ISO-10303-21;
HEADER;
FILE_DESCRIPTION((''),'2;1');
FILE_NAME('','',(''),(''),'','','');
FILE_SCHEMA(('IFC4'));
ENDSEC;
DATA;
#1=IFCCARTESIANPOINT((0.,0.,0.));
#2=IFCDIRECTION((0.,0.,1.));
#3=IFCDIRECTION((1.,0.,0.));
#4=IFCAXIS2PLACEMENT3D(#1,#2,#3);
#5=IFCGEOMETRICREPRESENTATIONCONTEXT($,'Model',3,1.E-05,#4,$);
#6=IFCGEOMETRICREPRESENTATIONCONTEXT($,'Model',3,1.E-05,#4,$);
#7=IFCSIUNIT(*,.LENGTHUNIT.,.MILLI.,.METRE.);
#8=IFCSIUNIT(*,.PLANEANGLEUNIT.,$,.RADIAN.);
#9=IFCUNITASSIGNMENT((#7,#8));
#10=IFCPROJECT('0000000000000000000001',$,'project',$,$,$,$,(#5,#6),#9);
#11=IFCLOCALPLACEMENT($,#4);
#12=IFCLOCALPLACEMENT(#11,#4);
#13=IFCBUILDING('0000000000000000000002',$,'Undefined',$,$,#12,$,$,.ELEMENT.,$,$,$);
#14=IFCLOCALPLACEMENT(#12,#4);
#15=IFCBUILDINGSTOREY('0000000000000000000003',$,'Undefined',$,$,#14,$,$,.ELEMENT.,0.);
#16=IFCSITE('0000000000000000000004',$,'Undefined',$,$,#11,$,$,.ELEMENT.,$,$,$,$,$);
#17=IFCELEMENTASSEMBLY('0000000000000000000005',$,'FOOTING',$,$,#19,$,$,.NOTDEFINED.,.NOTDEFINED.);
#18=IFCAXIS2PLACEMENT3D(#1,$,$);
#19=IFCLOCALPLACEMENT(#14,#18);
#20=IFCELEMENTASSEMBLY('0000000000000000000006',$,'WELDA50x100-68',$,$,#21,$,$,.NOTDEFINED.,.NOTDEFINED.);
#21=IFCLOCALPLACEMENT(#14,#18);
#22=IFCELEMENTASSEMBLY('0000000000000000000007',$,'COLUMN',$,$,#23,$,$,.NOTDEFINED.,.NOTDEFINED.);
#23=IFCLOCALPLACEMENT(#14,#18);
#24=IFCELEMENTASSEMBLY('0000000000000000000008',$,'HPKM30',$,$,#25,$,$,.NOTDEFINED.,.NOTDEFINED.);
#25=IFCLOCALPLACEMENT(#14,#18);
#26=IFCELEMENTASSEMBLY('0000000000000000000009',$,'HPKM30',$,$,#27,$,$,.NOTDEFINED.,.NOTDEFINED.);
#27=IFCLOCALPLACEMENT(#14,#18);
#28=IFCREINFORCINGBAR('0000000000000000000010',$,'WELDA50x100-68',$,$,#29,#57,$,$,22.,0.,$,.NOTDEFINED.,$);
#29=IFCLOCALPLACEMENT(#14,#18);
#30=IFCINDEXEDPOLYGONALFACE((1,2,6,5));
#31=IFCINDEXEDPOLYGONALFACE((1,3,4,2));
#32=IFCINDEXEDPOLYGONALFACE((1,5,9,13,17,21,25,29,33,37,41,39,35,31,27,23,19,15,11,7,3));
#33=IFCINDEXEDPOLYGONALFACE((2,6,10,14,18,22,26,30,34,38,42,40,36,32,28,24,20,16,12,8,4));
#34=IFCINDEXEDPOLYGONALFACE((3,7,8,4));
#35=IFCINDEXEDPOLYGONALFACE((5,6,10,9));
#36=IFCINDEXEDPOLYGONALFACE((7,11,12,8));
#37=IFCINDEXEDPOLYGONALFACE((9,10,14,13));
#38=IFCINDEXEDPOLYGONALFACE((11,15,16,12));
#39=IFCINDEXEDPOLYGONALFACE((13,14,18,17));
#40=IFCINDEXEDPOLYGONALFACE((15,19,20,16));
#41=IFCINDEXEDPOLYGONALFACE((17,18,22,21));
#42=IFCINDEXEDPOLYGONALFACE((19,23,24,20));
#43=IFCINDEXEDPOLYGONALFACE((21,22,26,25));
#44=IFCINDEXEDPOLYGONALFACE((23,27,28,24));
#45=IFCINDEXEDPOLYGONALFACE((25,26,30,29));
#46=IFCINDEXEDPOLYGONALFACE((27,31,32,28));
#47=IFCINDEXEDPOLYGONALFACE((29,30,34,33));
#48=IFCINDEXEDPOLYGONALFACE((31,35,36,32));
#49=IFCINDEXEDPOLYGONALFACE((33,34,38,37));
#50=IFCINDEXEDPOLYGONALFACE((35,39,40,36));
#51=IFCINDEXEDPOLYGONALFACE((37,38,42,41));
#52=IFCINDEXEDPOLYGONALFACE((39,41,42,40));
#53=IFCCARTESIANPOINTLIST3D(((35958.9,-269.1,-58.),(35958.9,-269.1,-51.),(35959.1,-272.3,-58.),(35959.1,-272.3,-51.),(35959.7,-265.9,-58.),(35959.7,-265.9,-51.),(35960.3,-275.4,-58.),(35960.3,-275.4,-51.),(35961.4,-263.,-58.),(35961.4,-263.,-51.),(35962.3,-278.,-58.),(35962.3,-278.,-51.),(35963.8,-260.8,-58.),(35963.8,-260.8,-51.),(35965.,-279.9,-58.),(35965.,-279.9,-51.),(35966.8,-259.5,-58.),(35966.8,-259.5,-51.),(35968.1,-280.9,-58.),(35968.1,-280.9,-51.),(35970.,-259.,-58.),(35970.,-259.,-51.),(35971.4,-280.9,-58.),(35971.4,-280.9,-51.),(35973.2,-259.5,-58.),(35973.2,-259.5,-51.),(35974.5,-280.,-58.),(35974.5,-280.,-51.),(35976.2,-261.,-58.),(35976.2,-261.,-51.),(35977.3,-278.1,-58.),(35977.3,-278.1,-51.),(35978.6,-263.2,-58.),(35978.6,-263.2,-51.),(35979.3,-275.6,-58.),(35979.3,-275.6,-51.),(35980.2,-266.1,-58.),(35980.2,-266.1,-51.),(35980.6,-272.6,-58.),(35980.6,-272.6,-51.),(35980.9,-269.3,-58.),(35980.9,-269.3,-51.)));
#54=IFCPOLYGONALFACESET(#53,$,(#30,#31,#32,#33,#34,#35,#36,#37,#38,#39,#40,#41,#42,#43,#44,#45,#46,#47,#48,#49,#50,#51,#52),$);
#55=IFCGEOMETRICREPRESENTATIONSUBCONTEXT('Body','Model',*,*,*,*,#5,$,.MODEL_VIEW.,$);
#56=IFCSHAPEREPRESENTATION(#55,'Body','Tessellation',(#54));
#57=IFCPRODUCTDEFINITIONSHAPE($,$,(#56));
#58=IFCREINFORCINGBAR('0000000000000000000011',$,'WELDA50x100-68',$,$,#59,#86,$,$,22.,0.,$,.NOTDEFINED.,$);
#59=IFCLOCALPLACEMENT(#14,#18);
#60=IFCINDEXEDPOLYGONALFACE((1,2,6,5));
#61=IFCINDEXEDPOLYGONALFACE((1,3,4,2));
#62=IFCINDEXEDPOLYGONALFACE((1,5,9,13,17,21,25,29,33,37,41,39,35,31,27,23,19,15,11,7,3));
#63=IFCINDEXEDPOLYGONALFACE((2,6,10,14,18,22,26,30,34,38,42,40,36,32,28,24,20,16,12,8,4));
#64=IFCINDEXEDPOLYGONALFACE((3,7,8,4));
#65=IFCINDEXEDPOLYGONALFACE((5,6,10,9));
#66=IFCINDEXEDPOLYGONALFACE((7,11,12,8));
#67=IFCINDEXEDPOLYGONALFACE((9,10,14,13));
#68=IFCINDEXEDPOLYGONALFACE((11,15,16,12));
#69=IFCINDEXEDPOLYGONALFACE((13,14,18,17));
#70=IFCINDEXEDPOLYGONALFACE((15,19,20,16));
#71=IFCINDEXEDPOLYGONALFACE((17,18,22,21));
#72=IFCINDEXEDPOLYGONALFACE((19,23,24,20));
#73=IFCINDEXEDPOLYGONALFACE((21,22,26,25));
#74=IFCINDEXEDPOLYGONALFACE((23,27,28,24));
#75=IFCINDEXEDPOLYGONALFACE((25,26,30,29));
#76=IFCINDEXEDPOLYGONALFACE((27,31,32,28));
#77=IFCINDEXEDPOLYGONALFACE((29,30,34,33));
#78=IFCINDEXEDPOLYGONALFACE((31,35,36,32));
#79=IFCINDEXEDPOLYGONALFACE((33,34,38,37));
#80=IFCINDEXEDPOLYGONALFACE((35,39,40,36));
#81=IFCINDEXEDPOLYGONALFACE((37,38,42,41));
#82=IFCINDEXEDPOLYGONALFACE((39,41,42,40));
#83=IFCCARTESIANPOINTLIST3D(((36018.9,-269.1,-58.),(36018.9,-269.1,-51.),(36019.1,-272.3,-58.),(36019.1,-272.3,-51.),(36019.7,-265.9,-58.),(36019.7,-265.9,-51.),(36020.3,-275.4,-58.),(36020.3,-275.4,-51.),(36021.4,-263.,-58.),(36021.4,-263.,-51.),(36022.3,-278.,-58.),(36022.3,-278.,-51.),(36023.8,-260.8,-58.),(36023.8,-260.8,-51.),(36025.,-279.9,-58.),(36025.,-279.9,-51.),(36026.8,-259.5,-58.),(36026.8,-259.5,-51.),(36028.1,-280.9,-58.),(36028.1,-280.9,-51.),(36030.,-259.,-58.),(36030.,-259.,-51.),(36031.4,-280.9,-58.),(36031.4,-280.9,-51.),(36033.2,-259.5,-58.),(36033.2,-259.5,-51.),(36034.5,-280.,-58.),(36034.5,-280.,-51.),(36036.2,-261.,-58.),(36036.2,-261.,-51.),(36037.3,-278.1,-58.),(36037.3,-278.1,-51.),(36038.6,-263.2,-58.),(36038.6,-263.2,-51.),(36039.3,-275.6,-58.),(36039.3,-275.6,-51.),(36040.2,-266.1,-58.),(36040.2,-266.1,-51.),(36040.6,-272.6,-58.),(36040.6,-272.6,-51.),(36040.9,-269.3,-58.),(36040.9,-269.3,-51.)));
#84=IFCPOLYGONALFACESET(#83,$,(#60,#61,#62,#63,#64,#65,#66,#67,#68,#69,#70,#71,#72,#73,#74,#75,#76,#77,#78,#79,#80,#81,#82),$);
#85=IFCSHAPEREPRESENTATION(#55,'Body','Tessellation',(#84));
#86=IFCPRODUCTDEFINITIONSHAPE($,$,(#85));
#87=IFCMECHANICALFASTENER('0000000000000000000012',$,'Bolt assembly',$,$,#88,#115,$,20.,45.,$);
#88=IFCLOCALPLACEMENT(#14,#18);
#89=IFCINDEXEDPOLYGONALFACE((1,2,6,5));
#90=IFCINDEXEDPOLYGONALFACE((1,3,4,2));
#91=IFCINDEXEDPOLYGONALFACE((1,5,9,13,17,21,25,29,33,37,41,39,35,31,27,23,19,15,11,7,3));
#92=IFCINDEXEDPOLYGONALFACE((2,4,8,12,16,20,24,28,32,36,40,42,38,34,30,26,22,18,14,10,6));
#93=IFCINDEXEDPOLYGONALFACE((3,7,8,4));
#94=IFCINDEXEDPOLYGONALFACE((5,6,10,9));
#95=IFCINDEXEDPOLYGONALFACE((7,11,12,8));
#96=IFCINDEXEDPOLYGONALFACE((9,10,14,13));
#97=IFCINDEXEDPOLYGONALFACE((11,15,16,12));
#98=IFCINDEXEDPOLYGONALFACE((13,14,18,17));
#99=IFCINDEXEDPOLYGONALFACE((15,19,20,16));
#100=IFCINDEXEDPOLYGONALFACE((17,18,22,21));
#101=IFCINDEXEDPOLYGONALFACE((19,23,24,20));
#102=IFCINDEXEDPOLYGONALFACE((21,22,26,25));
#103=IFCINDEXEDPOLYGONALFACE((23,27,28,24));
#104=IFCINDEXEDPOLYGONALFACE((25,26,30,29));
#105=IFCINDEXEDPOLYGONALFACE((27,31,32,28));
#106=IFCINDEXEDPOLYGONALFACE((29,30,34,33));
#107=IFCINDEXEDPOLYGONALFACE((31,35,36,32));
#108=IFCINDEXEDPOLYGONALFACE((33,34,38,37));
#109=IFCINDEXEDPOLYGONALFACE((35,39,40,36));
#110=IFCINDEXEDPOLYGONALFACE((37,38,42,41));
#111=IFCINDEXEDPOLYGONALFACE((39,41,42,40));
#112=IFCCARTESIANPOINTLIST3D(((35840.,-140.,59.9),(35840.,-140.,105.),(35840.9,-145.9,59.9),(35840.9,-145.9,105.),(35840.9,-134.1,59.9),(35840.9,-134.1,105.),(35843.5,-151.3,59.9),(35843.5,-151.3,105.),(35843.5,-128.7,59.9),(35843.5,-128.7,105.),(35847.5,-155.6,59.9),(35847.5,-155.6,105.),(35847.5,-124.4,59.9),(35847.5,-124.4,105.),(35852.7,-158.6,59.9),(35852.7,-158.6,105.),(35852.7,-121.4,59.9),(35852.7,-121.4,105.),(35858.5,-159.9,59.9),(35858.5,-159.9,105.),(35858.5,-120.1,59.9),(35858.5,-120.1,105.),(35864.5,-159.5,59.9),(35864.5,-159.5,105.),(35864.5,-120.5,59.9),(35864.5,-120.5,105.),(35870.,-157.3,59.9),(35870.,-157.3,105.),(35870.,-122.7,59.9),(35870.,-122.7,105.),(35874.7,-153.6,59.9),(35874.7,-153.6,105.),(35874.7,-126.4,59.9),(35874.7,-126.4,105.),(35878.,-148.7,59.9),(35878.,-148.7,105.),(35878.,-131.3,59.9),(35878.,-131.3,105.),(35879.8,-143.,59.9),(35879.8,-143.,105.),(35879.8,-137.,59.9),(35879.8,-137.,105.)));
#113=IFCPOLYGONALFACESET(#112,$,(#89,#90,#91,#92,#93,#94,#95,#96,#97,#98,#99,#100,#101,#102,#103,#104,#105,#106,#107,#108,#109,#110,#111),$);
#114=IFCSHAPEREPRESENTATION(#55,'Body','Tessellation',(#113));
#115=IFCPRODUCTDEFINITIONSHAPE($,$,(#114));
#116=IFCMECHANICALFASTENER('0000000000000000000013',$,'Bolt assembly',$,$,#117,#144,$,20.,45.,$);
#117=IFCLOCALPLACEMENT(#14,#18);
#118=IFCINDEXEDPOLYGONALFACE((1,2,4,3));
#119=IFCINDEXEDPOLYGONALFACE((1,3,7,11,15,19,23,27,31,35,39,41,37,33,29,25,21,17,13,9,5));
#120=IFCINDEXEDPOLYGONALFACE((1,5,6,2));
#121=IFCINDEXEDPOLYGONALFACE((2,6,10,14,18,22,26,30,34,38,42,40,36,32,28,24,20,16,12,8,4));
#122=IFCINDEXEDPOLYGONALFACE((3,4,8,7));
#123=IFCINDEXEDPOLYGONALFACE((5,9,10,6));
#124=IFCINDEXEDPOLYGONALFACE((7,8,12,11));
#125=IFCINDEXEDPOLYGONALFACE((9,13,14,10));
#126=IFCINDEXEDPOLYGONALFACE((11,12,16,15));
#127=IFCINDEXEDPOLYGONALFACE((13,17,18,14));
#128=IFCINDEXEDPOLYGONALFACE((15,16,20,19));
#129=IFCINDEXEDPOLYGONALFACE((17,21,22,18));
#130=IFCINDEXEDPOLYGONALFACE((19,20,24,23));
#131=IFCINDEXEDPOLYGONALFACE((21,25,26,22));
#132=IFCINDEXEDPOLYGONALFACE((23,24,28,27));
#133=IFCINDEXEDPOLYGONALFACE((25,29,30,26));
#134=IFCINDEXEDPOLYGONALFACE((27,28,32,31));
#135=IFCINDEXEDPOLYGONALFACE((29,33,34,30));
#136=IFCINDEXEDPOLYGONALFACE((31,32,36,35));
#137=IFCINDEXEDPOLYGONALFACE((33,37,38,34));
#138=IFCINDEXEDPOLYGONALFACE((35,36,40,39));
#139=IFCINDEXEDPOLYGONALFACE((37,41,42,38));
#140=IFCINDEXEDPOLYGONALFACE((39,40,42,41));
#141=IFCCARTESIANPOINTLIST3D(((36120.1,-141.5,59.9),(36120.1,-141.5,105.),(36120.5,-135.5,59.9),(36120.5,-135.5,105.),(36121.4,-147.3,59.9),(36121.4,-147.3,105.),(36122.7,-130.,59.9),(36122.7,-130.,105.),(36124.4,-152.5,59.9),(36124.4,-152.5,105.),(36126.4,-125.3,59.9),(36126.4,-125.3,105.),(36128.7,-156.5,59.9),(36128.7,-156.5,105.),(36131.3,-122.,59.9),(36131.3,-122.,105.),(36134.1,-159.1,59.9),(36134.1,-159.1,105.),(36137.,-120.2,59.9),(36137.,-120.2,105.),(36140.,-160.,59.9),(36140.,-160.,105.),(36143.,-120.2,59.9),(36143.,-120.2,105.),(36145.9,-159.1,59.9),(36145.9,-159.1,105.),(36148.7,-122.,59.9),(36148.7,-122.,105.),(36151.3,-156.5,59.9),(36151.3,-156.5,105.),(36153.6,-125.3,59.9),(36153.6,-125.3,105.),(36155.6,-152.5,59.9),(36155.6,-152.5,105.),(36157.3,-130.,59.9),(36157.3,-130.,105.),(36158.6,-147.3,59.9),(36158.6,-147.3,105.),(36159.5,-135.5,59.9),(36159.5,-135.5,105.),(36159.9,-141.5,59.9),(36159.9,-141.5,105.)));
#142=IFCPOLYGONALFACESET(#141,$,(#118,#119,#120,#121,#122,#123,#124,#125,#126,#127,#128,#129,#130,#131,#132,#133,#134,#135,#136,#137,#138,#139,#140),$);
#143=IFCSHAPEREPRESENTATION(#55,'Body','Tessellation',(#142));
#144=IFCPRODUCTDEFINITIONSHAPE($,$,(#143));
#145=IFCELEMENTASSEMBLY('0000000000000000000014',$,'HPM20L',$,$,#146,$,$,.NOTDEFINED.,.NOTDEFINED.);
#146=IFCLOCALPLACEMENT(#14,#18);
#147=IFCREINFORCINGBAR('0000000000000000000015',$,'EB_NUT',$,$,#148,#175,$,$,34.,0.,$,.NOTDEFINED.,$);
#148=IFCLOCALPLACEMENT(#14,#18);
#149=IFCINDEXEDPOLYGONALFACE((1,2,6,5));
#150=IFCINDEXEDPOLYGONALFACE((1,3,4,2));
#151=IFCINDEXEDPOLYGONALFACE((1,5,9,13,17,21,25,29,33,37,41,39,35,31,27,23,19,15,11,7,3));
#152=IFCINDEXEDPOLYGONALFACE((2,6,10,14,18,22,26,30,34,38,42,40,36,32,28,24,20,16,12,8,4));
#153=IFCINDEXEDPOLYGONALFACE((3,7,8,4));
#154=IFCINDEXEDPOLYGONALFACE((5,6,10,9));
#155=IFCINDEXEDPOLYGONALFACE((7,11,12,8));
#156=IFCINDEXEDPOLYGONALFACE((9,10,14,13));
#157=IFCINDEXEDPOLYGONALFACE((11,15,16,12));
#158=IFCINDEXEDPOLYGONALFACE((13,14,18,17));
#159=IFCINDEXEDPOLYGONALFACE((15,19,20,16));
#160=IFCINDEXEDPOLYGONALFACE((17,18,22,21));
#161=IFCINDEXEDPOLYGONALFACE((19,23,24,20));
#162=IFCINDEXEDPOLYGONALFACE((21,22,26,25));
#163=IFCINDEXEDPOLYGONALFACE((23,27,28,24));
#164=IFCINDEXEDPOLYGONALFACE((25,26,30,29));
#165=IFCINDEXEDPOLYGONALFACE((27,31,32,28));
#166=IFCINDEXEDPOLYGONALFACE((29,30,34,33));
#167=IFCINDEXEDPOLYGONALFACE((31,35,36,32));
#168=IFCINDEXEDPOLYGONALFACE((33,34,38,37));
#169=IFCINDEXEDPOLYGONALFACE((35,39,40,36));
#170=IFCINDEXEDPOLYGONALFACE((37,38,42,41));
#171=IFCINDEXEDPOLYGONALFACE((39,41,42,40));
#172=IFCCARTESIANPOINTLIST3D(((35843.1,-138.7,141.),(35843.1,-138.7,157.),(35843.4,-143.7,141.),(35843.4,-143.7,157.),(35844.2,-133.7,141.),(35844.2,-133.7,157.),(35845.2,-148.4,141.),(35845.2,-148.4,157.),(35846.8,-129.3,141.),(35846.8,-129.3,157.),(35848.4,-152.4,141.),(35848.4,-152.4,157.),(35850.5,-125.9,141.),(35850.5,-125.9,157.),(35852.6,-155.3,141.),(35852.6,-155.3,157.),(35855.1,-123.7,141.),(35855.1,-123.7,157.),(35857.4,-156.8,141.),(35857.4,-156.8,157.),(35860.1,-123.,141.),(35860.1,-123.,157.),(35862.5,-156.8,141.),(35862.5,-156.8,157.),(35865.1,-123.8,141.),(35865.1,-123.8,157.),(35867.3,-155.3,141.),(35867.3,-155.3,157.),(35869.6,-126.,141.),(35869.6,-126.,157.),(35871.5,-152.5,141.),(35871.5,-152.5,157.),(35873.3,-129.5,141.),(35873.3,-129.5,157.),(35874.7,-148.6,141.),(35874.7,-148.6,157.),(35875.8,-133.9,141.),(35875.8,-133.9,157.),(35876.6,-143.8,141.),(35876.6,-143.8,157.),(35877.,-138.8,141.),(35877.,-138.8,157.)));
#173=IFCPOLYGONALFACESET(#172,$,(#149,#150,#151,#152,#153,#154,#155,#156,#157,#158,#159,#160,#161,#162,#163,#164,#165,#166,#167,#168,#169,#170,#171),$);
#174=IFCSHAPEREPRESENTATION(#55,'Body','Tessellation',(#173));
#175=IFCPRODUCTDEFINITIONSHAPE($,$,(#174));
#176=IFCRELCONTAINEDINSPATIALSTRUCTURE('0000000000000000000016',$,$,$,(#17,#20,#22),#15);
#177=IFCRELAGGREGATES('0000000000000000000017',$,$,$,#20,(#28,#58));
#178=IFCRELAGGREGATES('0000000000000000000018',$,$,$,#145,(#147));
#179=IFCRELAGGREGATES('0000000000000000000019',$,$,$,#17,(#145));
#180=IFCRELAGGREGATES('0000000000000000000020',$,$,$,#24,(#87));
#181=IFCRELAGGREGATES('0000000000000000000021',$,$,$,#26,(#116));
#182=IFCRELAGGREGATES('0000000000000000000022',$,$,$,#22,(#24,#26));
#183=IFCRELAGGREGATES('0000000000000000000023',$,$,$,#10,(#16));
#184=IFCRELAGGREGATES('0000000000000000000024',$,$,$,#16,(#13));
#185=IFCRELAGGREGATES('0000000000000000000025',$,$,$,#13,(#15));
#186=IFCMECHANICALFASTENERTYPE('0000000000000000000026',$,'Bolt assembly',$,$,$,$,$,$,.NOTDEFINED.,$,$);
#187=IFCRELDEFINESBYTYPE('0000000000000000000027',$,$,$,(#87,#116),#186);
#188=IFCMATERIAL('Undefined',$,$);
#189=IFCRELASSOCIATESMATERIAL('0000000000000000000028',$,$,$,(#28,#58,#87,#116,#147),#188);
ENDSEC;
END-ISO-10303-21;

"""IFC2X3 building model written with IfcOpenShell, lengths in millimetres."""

from ifc_helpers import new_model, entity, si_unit, frame, origin_with_axes, origin_2d_with_axis, place, context, subcontext, project, spatial, circle, extrude, source, transform, mapped, material, type_object, element, aggregate, save


model = new_model("IFC2X3")

# Units and contexts
model_context_1 = context("Model", 3, precision=1e-05, world=origin_with_axes())
model_context_2 = context("Model", 3, precision=1e-05, world=origin_with_axes())
body_context = subcontext(model_context_1, "Body", "Model", "MODEL_VIEW")
ifc_project = project(units=[si_unit("LENGTHUNIT", "METRE", prefix="MILLI"), si_unit("PLANEANGLEUNIT", "RADIAN")], contexts=[model_context_1, model_context_2])

# Site, building, storey
site_placement = place(None, origin_with_axes())
site = spatial("IfcSite", under=ifc_project, at=site_placement, Name="Undefined", CompositionType="ELEMENT")
building_placement = place(site_placement, origin_with_axes())
building = spatial("IfcBuilding", under=site, at=building_placement, Name="Undefined", CompositionType="ELEMENT")
storey_placement = place(building_placement, origin_with_axes())
storey = spatial("IfcBuildingStorey", under=building, at=storey_placement, Name="Undefined", CompositionType="ELEMENT", Elevation=0.0)

# Element assembly
assembly_1_placement = place(storey_placement, origin_with_axes())
assembly_1 = element("IfcElementAssembly", 1, at=assembly_1_placement, inside=storey, Name="FOOTING", AssemblyPlace="NOTDEFINED", PredefinedType="NOTDEFINED")

# Element assembly
assembly_2_placement = place(storey_placement, origin_with_axes())
assembly_2 = element("IfcElementAssembly", 2, at=assembly_2_placement, inside=storey, Name="WELDA50x100-68", AssemblyPlace="NOTDEFINED", PredefinedType="NOTDEFINED")

# Element assemblies
assembly_3_placement = place(storey_placement, origin_with_axes())
assembly_3 = element("IfcElementAssembly", 3, at=assembly_3_placement, inside=storey, Name="COLUMN", AssemblyPlace="NOTDEFINED", PredefinedType="NOTDEFINED")
assembly_4_placement = place(assembly_3_placement, origin_with_axes())
assembly_4 = element("IfcElementAssembly", 4, at=assembly_4_placement, Name="HPKM30", AssemblyPlace="NOTDEFINED", PredefinedType="NOTDEFINED")
assembly_5_placement = place(assembly_3_placement, origin_with_axes())
assembly_5 = element("IfcElementAssembly", 5, at=assembly_5_placement, Name="HPKM30", AssemblyPlace="NOTDEFINED", PredefinedType="NOTDEFINED")

# Reinforcing bars
ifc_material_1 = material(Name="Undefined")
shared_shape_1 = source(origin_with_axes(), body_context, "Body", "AdvancedSweptSolid", [
    entity("IfcSweptDiskSolid", entity("IfcTrimmedCurve", entity("IfcLine", entity("IfcCartesianPoint", [0.0, 0.0, 0.0]), entity("IfcVector", entity("IfcDirection", [1.0, 0.0, 0.0]), 1.0)), [entity("IfcParameterValue", 0.0)], [entity("IfcParameterValue", 7.0)], True, "PARAMETER"), 11.0, None, 0.0, 7.0),
])
reinforcing_bar_1_placement = place(assembly_2_placement, frame((35969.9, -270.0, -51.0), z_axis=(0.011111, 0.999938, 0.0), x_axis=(0.0, 0.0, -1.0)))
reinforcing_bar_1 = element("IfcReinforcingBar", 6, at=reinforcing_bar_1_placement, material=ifc_material_1, Name="WELDA50x100-68", BarRole="NOTDEFINED", CrossSectionArea=0.0, NominalDiameter=22.0, context=body_context, shape_type="MappedRepresentation", body=[
    mapped(shared_shape_1, transform((0.0, 0.0, 0.0))),
])
shared_shape_2 = source(origin_with_axes(), body_context, "Body", "AdvancedSweptSolid", [
    entity("IfcSweptDiskSolid", entity("IfcTrimmedCurve", entity("IfcLine", entity("IfcCartesianPoint", [0.0, 0.0, 0.0]), entity("IfcVector", entity("IfcDirection", [1.0, 0.0, 0.0]), 1.0)), [entity("IfcParameterValue", 0.0)], [entity("IfcParameterValue", 7.0)], True, "PARAMETER"), 11.0, None, 0.0, 7.0),
])
reinforcing_bar_2_placement = place(assembly_2_placement, frame((36029.9, -270.0, -51.0), z_axis=(0.011111, 0.999938, 0.0), x_axis=(0.0, 0.0, -1.0)))
reinforcing_bar_2 = element("IfcReinforcingBar", 7, at=reinforcing_bar_2_placement, material=ifc_material_1, Name="WELDA50x100-68", BarRole="NOTDEFINED", CrossSectionArea=0.0, NominalDiameter=22.0, context=body_context, shape_type="MappedRepresentation", body=[
    mapped(shared_shape_2, transform((0.0, 0.0, 0.0))),
])
aggregate(assembly_2, [reinforcing_bar_1, reinforcing_bar_2])

# Mechanical fasteners
mechanical_fastener_type = type_object("IfcMechanicalFastenerType", Name="Bolt assembly")
shared_shape_3 = source(origin_with_axes(), body_context, "Body", "SweptSolid", [
    extrude(circle(Radius=20.0, at=origin_2d_with_axis()), frame((0.0, -45.0, 0.0), z_axis=(0.0, 1.0, 0.0), x_axis=(1.0, 0.0, 0.0)), (0.0, 0.0, 1.0), 45.1),
])
mechanical_fastener_1_placement = place(assembly_4_placement, frame((35860.0, -140.0, 60.0), z_axis=(0.0, -1.0, 0.0), x_axis=(-1.0, 0.0, 0.0)))
mechanical_fastener_1 = element("IfcMechanicalFastener", 8, at=mechanical_fastener_1_placement, type_object=mechanical_fastener_type, material=ifc_material_1, Name="Bolt assembly", NominalDiameter=20.0, NominalLength=45.0, context=body_context, shape_type="MappedRepresentation", body=[
    mapped(shared_shape_3, transform((0.0, 0.0, 0.0))),
])
mechanical_fastener_2_placement = place(assembly_5_placement, frame((36140.0, -140.0, 60.0), z_axis=(1.0, 0.0, 0.0), x_axis=(0.0, -1.0, 0.0)))
mechanical_fastener_2 = element("IfcMechanicalFastener", 9, at=mechanical_fastener_2_placement, type_object=mechanical_fastener_type, material=ifc_material_1, Name="Bolt assembly", NominalDiameter=20.0, NominalLength=45.0, context=body_context, shape_type="MappedRepresentation", body=[
    mapped(shared_shape_3, transform((0.0, 0.0, 0.0))),
])

# Element assembly, reinforcing bar
assembly_6_placement = place(assembly_1_placement, origin_with_axes())
assembly_6 = element("IfcElementAssembly", 10, at=assembly_6_placement, Name="HPM20L", AssemblyPlace="NOTDEFINED", PredefinedType="NOTDEFINED")
shared_shape_4 = source(origin_with_axes(), body_context, "Body", "AdvancedSweptSolid", [
    entity("IfcSweptDiskSolid", entity("IfcTrimmedCurve", entity("IfcLine", entity("IfcCartesianPoint", [0.0, 0.0, 0.0]), entity("IfcVector", entity("IfcDirection", [1.0, 0.0, 0.0]), 1.0)), [entity("IfcParameterValue", 0.0)], [entity("IfcParameterValue", 16.0)], True, "PARAMETER"), 17.0, None, 0.0, 16.0),
])
reinforcing_bar_3_placement = place(assembly_6_placement, frame((35860.0, -140.0, 157.0), z_axis=(0.003904, 0.999992, 0.0), x_axis=(0.0, 0.0, -1.0)))
reinforcing_bar_3 = element("IfcReinforcingBar", 11, at=reinforcing_bar_3_placement, material=ifc_material_1, Name="EB_NUT", BarRole="NOTDEFINED", CrossSectionArea=0.0, NominalDiameter=34.0, context=body_context, shape_type="MappedRepresentation", body=[
    mapped(shared_shape_4, transform((0.0, 0.0, 0.0))),
])
aggregate(assembly_6, [reinforcing_bar_3])

aggregate(assembly_1, [assembly_6])

aggregate(assembly_4, [mechanical_fastener_1])
aggregate(assembly_5, [mechanical_fastener_2])
aggregate(assembly_3, [assembly_4, assembly_5])

save(model, "model.ifc")
